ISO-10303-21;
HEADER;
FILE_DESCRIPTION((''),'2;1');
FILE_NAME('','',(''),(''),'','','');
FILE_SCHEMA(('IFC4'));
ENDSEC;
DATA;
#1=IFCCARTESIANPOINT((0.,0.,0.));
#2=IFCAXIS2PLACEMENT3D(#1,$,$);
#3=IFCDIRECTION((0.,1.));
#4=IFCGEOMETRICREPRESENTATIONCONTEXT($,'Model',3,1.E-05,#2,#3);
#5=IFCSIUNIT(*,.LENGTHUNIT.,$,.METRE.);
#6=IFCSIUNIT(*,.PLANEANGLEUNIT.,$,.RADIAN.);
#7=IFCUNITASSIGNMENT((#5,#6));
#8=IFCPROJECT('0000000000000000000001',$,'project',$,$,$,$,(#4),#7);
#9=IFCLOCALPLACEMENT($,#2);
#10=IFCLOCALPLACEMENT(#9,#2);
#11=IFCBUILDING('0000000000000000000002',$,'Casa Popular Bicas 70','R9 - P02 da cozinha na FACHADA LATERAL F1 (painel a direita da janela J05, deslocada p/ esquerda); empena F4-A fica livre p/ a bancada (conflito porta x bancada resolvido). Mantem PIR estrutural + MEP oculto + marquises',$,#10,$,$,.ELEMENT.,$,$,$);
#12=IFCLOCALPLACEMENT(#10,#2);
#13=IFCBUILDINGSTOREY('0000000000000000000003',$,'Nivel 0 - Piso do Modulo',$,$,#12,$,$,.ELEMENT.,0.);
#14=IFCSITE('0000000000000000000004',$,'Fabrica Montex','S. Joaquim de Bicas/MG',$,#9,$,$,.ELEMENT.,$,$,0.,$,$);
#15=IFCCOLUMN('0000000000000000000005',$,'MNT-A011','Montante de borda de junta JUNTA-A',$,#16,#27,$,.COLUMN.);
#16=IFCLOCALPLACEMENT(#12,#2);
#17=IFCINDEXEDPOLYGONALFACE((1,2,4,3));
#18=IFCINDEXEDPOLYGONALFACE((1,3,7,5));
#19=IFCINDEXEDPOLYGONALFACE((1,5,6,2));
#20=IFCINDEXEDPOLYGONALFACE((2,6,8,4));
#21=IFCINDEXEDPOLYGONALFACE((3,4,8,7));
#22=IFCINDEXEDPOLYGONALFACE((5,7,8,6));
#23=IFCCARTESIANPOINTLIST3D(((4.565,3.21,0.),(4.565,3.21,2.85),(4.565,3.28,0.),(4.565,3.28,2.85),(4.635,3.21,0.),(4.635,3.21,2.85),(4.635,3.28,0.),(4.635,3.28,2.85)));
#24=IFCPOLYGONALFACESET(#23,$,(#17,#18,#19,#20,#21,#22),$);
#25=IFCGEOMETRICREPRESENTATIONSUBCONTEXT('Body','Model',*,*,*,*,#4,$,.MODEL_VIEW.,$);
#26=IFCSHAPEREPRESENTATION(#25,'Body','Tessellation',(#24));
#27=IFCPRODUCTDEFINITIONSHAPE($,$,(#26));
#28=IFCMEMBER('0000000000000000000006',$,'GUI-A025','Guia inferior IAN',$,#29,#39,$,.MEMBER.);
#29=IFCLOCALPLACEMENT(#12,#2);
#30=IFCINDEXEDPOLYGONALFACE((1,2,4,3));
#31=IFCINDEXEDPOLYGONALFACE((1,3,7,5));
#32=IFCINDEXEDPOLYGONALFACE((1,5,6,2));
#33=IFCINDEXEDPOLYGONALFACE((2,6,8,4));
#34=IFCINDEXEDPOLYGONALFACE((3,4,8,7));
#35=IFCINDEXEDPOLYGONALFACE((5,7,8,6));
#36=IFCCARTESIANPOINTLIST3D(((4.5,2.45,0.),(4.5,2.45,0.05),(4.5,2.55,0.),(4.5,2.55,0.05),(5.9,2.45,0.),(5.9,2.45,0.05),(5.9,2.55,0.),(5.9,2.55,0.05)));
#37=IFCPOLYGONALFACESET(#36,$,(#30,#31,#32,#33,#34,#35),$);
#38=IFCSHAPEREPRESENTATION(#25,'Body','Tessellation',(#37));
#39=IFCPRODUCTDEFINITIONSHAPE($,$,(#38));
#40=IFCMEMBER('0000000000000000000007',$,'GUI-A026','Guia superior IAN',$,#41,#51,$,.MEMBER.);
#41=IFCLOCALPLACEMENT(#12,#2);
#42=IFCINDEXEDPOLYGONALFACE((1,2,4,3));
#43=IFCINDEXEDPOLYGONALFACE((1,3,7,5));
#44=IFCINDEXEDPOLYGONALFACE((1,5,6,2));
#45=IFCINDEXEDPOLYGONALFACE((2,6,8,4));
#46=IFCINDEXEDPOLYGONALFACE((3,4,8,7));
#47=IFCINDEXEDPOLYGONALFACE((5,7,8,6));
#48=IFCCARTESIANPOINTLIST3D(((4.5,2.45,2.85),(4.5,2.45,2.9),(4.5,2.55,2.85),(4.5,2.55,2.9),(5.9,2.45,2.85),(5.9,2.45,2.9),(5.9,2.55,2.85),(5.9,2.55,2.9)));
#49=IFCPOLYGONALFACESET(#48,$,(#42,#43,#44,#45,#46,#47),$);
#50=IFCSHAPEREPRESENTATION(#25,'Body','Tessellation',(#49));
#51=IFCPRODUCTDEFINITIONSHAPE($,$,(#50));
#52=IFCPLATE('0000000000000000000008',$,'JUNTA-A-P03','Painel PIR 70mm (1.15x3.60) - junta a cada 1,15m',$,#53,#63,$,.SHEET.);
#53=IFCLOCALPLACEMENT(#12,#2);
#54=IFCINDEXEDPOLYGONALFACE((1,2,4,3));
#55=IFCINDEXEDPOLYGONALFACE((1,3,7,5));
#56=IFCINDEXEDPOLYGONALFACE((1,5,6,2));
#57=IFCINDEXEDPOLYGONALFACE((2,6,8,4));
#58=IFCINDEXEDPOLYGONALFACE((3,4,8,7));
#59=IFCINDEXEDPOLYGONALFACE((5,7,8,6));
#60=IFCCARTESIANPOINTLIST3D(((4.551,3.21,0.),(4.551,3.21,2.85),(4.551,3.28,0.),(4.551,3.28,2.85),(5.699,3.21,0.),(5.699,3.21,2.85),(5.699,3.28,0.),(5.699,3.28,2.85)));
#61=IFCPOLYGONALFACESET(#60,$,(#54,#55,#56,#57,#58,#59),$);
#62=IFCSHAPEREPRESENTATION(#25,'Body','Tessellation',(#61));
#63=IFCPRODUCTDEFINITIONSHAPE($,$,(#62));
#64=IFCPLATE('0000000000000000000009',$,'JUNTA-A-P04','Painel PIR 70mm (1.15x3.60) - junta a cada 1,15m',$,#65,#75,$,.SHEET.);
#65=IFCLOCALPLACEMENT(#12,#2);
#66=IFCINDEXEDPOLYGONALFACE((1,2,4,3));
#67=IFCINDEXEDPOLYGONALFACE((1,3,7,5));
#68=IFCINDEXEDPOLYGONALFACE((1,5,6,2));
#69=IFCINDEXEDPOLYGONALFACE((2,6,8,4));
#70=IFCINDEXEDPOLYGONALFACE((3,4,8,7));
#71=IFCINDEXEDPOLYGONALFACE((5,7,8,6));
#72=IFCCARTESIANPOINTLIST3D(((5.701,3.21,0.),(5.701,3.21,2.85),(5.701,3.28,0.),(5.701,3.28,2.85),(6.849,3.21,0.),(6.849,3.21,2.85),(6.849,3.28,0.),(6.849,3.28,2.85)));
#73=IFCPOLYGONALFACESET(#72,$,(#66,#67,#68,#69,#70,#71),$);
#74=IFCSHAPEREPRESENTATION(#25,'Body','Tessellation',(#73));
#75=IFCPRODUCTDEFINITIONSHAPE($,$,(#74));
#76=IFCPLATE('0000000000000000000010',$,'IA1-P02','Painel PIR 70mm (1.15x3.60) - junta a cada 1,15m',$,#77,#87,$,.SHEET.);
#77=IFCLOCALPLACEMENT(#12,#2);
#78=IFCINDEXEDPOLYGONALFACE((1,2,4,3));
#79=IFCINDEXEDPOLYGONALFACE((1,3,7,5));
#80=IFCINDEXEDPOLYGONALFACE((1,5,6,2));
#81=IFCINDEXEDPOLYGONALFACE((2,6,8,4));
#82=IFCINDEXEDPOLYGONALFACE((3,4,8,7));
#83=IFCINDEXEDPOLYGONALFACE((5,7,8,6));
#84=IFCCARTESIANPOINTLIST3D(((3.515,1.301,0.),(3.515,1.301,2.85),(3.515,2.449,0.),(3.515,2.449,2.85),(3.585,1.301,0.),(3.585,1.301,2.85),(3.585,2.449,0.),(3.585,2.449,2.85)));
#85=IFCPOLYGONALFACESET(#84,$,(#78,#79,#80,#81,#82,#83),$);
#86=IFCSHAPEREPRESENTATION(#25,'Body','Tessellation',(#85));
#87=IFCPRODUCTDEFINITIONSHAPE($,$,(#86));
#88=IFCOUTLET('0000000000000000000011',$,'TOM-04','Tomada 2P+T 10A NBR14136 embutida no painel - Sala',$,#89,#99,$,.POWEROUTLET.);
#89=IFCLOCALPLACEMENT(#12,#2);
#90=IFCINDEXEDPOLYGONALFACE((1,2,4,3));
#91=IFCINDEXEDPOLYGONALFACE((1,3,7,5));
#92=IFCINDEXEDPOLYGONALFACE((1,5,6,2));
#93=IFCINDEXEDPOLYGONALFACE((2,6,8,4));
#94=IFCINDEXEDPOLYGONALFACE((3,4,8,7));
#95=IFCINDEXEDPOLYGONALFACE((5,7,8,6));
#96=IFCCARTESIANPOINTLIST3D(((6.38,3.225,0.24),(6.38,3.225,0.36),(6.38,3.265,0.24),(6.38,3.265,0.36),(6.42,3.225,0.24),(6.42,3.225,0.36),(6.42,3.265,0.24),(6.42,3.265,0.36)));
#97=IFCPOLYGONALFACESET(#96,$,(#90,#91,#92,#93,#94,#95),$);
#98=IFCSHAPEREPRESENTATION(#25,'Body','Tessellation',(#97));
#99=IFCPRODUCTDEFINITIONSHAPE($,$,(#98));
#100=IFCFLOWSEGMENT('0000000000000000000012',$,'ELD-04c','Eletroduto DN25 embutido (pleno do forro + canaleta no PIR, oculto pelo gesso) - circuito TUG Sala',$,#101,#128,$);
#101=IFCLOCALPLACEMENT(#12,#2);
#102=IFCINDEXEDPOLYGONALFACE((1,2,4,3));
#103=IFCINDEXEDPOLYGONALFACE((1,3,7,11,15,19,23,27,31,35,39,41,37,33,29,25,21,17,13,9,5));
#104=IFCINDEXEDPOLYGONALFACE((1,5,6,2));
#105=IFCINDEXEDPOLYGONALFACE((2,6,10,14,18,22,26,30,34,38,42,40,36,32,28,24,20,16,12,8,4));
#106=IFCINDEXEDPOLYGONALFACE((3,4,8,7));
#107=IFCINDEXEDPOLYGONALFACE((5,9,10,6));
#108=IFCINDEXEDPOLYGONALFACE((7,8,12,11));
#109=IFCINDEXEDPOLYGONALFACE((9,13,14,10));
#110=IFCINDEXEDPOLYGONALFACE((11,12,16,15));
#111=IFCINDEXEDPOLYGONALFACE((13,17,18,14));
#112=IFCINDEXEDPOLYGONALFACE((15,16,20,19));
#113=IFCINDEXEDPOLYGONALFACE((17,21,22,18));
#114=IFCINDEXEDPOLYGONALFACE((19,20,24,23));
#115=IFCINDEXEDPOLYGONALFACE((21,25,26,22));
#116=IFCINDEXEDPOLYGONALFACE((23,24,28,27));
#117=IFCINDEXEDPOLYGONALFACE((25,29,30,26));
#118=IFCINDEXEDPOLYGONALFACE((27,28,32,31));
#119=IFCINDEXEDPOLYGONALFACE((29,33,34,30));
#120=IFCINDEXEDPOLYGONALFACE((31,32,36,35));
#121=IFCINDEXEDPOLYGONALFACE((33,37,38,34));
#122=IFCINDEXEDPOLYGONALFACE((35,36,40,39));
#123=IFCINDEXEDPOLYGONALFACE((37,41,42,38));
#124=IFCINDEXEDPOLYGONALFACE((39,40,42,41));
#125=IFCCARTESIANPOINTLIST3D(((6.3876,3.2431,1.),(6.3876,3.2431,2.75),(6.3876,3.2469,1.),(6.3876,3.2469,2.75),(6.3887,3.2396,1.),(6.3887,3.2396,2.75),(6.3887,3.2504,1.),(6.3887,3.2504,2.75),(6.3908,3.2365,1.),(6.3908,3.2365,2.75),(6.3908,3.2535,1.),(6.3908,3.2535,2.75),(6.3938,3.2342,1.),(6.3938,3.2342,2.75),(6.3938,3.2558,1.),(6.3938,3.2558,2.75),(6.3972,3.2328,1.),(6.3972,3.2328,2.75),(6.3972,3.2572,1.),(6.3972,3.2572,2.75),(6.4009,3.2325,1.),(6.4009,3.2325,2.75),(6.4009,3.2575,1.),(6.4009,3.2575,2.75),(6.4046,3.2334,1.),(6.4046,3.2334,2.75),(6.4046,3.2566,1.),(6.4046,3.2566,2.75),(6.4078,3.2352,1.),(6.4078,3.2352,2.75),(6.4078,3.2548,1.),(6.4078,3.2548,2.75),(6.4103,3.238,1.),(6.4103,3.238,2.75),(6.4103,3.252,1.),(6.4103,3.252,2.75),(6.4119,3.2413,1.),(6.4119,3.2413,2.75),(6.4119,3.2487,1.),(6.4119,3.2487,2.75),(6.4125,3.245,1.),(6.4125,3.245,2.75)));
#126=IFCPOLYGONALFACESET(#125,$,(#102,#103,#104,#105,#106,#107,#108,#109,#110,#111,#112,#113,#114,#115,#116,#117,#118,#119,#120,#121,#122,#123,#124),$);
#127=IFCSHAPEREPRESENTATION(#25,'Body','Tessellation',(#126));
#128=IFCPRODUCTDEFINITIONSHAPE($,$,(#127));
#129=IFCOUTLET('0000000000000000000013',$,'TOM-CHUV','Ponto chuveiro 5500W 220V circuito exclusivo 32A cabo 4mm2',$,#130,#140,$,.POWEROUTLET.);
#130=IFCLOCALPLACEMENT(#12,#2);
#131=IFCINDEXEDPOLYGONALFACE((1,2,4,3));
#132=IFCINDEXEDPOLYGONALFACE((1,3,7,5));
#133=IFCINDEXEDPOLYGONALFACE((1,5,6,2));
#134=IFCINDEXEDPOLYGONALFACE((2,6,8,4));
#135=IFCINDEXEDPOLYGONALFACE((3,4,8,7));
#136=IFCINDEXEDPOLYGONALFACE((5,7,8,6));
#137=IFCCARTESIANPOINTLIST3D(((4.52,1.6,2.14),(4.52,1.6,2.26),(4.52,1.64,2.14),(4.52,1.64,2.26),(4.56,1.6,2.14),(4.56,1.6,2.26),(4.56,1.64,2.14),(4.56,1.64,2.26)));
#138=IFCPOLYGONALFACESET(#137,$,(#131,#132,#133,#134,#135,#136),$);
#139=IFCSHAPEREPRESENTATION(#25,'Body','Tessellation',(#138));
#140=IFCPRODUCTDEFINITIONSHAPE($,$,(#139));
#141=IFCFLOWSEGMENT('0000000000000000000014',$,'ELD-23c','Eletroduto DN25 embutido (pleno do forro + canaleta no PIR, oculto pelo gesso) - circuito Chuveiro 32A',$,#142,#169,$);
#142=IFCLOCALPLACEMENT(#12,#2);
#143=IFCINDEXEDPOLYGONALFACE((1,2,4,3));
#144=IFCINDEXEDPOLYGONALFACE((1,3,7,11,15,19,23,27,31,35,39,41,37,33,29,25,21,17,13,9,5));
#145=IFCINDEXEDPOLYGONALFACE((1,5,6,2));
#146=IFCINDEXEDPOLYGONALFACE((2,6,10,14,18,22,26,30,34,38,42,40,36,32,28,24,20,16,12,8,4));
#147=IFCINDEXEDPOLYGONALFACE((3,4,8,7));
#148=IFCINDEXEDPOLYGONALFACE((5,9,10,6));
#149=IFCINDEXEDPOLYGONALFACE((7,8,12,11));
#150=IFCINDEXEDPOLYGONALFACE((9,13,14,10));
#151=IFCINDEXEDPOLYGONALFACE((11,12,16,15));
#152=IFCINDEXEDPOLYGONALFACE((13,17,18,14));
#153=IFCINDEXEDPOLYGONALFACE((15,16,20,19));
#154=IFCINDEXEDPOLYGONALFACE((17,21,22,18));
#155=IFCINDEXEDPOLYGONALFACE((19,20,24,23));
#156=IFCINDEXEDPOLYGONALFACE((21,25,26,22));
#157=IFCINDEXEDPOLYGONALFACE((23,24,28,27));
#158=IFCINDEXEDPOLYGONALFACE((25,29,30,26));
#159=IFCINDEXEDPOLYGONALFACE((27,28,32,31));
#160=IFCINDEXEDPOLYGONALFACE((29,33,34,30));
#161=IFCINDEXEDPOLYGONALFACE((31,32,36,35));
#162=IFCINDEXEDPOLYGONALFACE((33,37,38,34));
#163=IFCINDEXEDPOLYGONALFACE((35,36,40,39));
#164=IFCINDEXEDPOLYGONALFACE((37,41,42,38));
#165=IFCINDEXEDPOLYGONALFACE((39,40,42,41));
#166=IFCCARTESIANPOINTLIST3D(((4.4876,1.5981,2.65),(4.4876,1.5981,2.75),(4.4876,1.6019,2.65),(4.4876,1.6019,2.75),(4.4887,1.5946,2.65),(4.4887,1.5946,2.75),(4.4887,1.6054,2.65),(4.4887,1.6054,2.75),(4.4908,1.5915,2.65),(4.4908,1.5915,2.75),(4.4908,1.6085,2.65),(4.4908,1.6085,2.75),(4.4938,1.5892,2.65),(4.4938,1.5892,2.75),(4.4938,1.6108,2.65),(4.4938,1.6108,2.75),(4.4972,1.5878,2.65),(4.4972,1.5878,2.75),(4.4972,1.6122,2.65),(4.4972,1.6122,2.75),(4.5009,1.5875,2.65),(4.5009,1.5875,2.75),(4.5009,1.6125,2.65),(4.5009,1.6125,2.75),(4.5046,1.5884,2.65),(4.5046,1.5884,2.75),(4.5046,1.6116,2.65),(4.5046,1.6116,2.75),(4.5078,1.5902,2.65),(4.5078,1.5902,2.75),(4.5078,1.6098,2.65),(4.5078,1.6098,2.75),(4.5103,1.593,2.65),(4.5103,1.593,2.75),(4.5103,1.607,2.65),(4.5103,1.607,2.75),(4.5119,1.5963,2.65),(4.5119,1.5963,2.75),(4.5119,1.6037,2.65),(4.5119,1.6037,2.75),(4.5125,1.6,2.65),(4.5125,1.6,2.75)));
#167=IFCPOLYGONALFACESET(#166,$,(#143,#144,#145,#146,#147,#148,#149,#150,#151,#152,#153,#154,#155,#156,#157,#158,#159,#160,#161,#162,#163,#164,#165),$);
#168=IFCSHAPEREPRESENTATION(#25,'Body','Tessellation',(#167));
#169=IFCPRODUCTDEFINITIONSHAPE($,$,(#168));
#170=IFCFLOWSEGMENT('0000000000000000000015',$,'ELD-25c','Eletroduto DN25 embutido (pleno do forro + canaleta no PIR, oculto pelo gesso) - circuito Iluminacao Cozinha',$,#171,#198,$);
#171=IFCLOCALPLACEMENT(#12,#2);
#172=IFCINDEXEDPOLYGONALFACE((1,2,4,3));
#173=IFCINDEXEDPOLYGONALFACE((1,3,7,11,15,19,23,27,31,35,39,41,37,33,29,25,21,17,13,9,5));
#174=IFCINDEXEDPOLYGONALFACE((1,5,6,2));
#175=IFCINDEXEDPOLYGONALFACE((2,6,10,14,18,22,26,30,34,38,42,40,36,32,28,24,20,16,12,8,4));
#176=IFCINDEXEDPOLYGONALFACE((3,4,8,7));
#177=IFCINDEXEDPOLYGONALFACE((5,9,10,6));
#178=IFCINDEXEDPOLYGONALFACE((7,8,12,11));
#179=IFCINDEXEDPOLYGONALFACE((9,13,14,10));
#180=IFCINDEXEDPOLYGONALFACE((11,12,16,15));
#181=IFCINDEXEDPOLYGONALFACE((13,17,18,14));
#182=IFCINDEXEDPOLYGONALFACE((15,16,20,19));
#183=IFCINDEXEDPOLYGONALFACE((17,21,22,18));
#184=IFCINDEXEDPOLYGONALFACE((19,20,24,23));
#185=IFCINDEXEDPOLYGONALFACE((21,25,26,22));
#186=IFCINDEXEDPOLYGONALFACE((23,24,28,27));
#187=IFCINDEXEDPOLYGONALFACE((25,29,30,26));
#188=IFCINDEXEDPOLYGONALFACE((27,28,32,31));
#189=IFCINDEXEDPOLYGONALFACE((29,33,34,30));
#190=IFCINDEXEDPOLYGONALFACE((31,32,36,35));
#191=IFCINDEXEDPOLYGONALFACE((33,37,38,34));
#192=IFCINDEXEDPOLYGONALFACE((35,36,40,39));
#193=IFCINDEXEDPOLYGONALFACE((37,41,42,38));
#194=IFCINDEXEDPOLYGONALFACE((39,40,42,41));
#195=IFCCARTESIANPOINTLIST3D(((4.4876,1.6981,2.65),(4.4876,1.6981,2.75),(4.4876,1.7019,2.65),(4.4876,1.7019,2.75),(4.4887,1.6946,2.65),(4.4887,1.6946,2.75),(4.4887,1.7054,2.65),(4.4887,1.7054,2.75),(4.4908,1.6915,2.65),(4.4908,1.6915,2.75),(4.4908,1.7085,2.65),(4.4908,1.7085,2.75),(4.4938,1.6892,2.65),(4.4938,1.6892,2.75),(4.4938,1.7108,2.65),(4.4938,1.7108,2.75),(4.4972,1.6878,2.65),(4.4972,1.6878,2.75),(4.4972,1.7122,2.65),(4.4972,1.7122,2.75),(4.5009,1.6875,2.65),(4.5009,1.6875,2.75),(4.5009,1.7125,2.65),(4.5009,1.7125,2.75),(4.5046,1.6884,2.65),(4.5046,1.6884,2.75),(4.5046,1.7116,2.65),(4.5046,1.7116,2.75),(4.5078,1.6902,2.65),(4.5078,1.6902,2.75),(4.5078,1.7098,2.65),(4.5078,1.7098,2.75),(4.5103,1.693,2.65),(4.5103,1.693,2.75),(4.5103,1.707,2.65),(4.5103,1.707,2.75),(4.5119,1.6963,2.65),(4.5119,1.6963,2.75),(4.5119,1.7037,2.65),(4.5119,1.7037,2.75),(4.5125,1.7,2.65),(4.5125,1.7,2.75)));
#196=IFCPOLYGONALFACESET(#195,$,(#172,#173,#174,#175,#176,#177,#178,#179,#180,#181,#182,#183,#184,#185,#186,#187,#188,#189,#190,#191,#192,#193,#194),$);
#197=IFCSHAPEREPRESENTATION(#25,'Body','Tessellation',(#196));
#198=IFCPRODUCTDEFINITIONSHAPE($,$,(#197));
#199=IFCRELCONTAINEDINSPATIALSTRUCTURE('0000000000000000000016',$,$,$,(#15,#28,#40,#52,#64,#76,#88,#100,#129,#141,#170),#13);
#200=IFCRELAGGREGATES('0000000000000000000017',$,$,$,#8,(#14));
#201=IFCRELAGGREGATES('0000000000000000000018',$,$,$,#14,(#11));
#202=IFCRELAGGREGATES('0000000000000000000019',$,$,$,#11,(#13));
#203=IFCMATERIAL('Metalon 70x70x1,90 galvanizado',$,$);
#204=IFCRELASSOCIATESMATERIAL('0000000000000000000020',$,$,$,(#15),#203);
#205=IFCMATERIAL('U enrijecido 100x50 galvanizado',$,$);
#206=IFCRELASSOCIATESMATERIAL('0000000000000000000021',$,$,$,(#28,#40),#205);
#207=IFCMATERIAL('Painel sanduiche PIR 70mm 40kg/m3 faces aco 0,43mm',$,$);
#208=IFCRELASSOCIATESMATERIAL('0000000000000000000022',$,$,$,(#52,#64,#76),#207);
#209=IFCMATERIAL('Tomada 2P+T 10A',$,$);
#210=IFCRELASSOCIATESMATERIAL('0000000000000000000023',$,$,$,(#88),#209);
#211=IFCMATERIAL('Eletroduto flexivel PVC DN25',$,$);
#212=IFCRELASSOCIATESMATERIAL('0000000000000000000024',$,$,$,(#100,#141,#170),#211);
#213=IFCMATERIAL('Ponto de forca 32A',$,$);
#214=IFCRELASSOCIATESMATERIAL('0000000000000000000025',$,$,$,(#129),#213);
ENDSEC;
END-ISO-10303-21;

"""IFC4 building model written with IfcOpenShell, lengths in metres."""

from ifc_helpers import new_model, si_unit, direction, frame, frame_2d, origin, origin_2d, place, context, subcontext, project, spatial, rectangle, circle, extrude, material, element, save


model = new_model("IFC4")

# Units and contexts
model_context = context("Model", 3, precision=1e-05, world=origin(), true_north=direction((0.0, 1.0)))
body_context = subcontext(model_context, "Body", "Model", "MODEL_VIEW")
ifc_project = project(units=[si_unit("LENGTHUNIT", "METRE"), si_unit("PLANEANGLEUNIT", "RADIAN")], contexts=[model_context])

# Site, building, storey
site_placement = place(None, origin())
site = spatial("IfcSite", under=ifc_project, at=site_placement, Name="Fabrica Montex", Description="S. Joaquim de Bicas/MG", CompositionType="ELEMENT", RefElevation=0.0)
building_placement = place(site_placement, origin())
building = spatial("IfcBuilding", under=site, at=building_placement, Name="Casa Popular Bicas 70", Description="R9 - P02 da cozinha na FACHADA LATERAL F1 (painel a direita da janela J05, deslocada p/ esquerda); empena F4-A fica livre p/ a bancada (conflito porta x bancada resolvido). Mantem PIR estrutural + MEP oculto + marquises", CompositionType="ELEMENT")
storey_placement = place(building_placement, origin())
storey = spatial("IfcBuildingStorey", under=building, at=storey_placement, Name="Nivel 0 - Piso do Modulo", CompositionType="ELEMENT", Elevation=0.0)

# Column
ifc_material_1 = material(Name="Metalon 70x70x1,90 galvanizado")
column_placement = place(storey_placement, frame((4.6, 3.245, 0.0)))
element("IfcColumn", 1, at=column_placement, inside=storey, material=ifc_material_1, Name="MNT-A011", Description="Montante de borda de junta JUNTA-A", PredefinedType="COLUMN", context=body_context, shape_type="SweptSolid", body=[
    extrude(rectangle(XDim=0.07, YDim=0.07, at=origin_2d()), origin(), (0.0, 0.0, 1.0), 2.85),
])

# Members
ifc_material_2 = material(Name="U enrijecido 100x50 galvanizado")
for number, where, z_axis, x_axis, name, description in (
    (2, (4.5, 2.5, 0.025), (1.0, 0.0, 0.0), (0.0, 0.0, 1.0), "GUI-A025", "Guia inferior IAN"),
    (3, (4.5, 2.5, 2.875), (1.0, 0.0, 0.0), (0.0, 0.0, 1.0), "GUI-A026", "Guia superior IAN"),
):
    element("IfcMember", number, at=place(storey_placement, frame(where, z_axis=z_axis, x_axis=x_axis)), inside=storey, material=ifc_material_2, Name=name, Description=description, PredefinedType="MEMBER", context=body_context, shape_type="SweptSolid", body=[
        extrude(rectangle(XDim=0.05, YDim=0.1, at=origin_2d()), origin(), (0.0, 0.0, 1.0), 1.4),
    ])

# Plates
ifc_material_3 = material(Name="Painel sanduiche PIR 70mm 40kg/m3 faces aco 0,43mm")
for number, where, x_axis, name in (
    (4, (4.551, 3.245, 0.0), (1.0, 0.0, 0.0), "JUNTA-A-P03"),
    (5, (5.701, 3.245, 0.0), (1.0, 0.0, 0.0), "JUNTA-A-P04"),
    (6, (3.55, 1.301, 0.0), (0.0, 1.0, 0.0), "IA1-P02"),
):
    element("IfcPlate", number, at=place(storey_placement, frame(where, x_axis=x_axis)), inside=storey, material=ifc_material_3, Name=name, Description="Painel PIR 70mm (1.15x3.60) - junta a cada 1,15m", PredefinedType="SHEET", context=body_context, shape_type="SweptSolid", body=[
        extrude(rectangle(XDim=1.148, YDim=0.07, at=frame_2d((0.574, 0.0))), origin(), (0.0, 0.0, 1.0), 2.85),
    ])

# Outlet
ifc_material_4 = material(Name="Tomada 2P+T 10A")
outlet_1_placement = place(storey_placement, frame((6.38, 3.225, 0.24)))
element("IfcOutlet", 7, at=outlet_1_placement, inside=storey, material=ifc_material_4, Name="TOM-04", Description="Tomada 2P+T 10A NBR14136 embutida no painel - Sala", PredefinedType="POWEROUTLET", context=body_context, shape_type="SweptSolid", body=[
    extrude(rectangle(XDim=0.04, YDim=0.04, at=frame_2d((0.02, 0.02))), origin(), (0.0, 0.0, 1.0), 0.12),
])

# Flow segment
ifc_material_5 = material(Name="Eletroduto flexivel PVC DN25")
flow_segment_1_placement = place(storey_placement, frame((6.4, 3.245, 2.75), z_axis=(0.0, 0.0, -1.0), x_axis=(1.0, 0.0, 0.0)))
element("IfcFlowSegment", 8, at=flow_segment_1_placement, inside=storey, material=ifc_material_5, Name="ELD-04c", Description="Eletroduto DN25 embutido (pleno do forro + canaleta no PIR, oculto pelo gesso) - circuito TUG Sala", context=body_context, shape_type="SweptSolid", body=[
    extrude(circle(Radius=0.0125, at=origin_2d()), origin(), (0.0, 0.0, 1.0), 1.75),
])

# Outlet
ifc_material_6 = material(Name="Ponto de forca 32A")
outlet_2_placement = place(storey_placement, frame((4.52, 1.6, 2.14)))
element("IfcOutlet", 9, at=outlet_2_placement, inside=storey, material=ifc_material_6, Name="TOM-CHUV", Description="Ponto chuveiro 5500W 220V circuito exclusivo 32A cabo 4mm2", PredefinedType="POWEROUTLET", context=body_context, shape_type="SweptSolid", body=[
    extrude(rectangle(XDim=0.04, YDim=0.04, at=frame_2d((0.02, 0.02))), origin(), (0.0, 0.0, 1.0), 0.12),
])

# Flow segments
for number, where, z_axis, x_axis, name, description in (
    (10, (4.5, 1.6, 2.75), (0.0, 0.0, -1.0), (1.0, 0.0, 0.0), "ELD-23c", "Eletroduto DN25 embutido (pleno do forro + canaleta no PIR, oculto pelo gesso) - circuito Chuveiro 32A"),
    (11, (4.5, 1.7, 2.75), (0.0, 0.0, -1.0), (1.0, 0.0, 0.0), "ELD-25c", "Eletroduto DN25 embutido (pleno do forro + canaleta no PIR, oculto pelo gesso) - circuito Iluminacao Cozinha"),
):
    element("IfcFlowSegment", number, at=place(storey_placement, frame(where, z_axis=z_axis, x_axis=x_axis)), inside=storey, material=ifc_material_5, Name=name, Description=description, context=body_context, shape_type="SweptSolid", body=[
        extrude(circle(Radius=0.0125, at=origin_2d()), origin(), (0.0, 0.0, 1.0), 0.1),
    ])

save(model, "model.ifc")
